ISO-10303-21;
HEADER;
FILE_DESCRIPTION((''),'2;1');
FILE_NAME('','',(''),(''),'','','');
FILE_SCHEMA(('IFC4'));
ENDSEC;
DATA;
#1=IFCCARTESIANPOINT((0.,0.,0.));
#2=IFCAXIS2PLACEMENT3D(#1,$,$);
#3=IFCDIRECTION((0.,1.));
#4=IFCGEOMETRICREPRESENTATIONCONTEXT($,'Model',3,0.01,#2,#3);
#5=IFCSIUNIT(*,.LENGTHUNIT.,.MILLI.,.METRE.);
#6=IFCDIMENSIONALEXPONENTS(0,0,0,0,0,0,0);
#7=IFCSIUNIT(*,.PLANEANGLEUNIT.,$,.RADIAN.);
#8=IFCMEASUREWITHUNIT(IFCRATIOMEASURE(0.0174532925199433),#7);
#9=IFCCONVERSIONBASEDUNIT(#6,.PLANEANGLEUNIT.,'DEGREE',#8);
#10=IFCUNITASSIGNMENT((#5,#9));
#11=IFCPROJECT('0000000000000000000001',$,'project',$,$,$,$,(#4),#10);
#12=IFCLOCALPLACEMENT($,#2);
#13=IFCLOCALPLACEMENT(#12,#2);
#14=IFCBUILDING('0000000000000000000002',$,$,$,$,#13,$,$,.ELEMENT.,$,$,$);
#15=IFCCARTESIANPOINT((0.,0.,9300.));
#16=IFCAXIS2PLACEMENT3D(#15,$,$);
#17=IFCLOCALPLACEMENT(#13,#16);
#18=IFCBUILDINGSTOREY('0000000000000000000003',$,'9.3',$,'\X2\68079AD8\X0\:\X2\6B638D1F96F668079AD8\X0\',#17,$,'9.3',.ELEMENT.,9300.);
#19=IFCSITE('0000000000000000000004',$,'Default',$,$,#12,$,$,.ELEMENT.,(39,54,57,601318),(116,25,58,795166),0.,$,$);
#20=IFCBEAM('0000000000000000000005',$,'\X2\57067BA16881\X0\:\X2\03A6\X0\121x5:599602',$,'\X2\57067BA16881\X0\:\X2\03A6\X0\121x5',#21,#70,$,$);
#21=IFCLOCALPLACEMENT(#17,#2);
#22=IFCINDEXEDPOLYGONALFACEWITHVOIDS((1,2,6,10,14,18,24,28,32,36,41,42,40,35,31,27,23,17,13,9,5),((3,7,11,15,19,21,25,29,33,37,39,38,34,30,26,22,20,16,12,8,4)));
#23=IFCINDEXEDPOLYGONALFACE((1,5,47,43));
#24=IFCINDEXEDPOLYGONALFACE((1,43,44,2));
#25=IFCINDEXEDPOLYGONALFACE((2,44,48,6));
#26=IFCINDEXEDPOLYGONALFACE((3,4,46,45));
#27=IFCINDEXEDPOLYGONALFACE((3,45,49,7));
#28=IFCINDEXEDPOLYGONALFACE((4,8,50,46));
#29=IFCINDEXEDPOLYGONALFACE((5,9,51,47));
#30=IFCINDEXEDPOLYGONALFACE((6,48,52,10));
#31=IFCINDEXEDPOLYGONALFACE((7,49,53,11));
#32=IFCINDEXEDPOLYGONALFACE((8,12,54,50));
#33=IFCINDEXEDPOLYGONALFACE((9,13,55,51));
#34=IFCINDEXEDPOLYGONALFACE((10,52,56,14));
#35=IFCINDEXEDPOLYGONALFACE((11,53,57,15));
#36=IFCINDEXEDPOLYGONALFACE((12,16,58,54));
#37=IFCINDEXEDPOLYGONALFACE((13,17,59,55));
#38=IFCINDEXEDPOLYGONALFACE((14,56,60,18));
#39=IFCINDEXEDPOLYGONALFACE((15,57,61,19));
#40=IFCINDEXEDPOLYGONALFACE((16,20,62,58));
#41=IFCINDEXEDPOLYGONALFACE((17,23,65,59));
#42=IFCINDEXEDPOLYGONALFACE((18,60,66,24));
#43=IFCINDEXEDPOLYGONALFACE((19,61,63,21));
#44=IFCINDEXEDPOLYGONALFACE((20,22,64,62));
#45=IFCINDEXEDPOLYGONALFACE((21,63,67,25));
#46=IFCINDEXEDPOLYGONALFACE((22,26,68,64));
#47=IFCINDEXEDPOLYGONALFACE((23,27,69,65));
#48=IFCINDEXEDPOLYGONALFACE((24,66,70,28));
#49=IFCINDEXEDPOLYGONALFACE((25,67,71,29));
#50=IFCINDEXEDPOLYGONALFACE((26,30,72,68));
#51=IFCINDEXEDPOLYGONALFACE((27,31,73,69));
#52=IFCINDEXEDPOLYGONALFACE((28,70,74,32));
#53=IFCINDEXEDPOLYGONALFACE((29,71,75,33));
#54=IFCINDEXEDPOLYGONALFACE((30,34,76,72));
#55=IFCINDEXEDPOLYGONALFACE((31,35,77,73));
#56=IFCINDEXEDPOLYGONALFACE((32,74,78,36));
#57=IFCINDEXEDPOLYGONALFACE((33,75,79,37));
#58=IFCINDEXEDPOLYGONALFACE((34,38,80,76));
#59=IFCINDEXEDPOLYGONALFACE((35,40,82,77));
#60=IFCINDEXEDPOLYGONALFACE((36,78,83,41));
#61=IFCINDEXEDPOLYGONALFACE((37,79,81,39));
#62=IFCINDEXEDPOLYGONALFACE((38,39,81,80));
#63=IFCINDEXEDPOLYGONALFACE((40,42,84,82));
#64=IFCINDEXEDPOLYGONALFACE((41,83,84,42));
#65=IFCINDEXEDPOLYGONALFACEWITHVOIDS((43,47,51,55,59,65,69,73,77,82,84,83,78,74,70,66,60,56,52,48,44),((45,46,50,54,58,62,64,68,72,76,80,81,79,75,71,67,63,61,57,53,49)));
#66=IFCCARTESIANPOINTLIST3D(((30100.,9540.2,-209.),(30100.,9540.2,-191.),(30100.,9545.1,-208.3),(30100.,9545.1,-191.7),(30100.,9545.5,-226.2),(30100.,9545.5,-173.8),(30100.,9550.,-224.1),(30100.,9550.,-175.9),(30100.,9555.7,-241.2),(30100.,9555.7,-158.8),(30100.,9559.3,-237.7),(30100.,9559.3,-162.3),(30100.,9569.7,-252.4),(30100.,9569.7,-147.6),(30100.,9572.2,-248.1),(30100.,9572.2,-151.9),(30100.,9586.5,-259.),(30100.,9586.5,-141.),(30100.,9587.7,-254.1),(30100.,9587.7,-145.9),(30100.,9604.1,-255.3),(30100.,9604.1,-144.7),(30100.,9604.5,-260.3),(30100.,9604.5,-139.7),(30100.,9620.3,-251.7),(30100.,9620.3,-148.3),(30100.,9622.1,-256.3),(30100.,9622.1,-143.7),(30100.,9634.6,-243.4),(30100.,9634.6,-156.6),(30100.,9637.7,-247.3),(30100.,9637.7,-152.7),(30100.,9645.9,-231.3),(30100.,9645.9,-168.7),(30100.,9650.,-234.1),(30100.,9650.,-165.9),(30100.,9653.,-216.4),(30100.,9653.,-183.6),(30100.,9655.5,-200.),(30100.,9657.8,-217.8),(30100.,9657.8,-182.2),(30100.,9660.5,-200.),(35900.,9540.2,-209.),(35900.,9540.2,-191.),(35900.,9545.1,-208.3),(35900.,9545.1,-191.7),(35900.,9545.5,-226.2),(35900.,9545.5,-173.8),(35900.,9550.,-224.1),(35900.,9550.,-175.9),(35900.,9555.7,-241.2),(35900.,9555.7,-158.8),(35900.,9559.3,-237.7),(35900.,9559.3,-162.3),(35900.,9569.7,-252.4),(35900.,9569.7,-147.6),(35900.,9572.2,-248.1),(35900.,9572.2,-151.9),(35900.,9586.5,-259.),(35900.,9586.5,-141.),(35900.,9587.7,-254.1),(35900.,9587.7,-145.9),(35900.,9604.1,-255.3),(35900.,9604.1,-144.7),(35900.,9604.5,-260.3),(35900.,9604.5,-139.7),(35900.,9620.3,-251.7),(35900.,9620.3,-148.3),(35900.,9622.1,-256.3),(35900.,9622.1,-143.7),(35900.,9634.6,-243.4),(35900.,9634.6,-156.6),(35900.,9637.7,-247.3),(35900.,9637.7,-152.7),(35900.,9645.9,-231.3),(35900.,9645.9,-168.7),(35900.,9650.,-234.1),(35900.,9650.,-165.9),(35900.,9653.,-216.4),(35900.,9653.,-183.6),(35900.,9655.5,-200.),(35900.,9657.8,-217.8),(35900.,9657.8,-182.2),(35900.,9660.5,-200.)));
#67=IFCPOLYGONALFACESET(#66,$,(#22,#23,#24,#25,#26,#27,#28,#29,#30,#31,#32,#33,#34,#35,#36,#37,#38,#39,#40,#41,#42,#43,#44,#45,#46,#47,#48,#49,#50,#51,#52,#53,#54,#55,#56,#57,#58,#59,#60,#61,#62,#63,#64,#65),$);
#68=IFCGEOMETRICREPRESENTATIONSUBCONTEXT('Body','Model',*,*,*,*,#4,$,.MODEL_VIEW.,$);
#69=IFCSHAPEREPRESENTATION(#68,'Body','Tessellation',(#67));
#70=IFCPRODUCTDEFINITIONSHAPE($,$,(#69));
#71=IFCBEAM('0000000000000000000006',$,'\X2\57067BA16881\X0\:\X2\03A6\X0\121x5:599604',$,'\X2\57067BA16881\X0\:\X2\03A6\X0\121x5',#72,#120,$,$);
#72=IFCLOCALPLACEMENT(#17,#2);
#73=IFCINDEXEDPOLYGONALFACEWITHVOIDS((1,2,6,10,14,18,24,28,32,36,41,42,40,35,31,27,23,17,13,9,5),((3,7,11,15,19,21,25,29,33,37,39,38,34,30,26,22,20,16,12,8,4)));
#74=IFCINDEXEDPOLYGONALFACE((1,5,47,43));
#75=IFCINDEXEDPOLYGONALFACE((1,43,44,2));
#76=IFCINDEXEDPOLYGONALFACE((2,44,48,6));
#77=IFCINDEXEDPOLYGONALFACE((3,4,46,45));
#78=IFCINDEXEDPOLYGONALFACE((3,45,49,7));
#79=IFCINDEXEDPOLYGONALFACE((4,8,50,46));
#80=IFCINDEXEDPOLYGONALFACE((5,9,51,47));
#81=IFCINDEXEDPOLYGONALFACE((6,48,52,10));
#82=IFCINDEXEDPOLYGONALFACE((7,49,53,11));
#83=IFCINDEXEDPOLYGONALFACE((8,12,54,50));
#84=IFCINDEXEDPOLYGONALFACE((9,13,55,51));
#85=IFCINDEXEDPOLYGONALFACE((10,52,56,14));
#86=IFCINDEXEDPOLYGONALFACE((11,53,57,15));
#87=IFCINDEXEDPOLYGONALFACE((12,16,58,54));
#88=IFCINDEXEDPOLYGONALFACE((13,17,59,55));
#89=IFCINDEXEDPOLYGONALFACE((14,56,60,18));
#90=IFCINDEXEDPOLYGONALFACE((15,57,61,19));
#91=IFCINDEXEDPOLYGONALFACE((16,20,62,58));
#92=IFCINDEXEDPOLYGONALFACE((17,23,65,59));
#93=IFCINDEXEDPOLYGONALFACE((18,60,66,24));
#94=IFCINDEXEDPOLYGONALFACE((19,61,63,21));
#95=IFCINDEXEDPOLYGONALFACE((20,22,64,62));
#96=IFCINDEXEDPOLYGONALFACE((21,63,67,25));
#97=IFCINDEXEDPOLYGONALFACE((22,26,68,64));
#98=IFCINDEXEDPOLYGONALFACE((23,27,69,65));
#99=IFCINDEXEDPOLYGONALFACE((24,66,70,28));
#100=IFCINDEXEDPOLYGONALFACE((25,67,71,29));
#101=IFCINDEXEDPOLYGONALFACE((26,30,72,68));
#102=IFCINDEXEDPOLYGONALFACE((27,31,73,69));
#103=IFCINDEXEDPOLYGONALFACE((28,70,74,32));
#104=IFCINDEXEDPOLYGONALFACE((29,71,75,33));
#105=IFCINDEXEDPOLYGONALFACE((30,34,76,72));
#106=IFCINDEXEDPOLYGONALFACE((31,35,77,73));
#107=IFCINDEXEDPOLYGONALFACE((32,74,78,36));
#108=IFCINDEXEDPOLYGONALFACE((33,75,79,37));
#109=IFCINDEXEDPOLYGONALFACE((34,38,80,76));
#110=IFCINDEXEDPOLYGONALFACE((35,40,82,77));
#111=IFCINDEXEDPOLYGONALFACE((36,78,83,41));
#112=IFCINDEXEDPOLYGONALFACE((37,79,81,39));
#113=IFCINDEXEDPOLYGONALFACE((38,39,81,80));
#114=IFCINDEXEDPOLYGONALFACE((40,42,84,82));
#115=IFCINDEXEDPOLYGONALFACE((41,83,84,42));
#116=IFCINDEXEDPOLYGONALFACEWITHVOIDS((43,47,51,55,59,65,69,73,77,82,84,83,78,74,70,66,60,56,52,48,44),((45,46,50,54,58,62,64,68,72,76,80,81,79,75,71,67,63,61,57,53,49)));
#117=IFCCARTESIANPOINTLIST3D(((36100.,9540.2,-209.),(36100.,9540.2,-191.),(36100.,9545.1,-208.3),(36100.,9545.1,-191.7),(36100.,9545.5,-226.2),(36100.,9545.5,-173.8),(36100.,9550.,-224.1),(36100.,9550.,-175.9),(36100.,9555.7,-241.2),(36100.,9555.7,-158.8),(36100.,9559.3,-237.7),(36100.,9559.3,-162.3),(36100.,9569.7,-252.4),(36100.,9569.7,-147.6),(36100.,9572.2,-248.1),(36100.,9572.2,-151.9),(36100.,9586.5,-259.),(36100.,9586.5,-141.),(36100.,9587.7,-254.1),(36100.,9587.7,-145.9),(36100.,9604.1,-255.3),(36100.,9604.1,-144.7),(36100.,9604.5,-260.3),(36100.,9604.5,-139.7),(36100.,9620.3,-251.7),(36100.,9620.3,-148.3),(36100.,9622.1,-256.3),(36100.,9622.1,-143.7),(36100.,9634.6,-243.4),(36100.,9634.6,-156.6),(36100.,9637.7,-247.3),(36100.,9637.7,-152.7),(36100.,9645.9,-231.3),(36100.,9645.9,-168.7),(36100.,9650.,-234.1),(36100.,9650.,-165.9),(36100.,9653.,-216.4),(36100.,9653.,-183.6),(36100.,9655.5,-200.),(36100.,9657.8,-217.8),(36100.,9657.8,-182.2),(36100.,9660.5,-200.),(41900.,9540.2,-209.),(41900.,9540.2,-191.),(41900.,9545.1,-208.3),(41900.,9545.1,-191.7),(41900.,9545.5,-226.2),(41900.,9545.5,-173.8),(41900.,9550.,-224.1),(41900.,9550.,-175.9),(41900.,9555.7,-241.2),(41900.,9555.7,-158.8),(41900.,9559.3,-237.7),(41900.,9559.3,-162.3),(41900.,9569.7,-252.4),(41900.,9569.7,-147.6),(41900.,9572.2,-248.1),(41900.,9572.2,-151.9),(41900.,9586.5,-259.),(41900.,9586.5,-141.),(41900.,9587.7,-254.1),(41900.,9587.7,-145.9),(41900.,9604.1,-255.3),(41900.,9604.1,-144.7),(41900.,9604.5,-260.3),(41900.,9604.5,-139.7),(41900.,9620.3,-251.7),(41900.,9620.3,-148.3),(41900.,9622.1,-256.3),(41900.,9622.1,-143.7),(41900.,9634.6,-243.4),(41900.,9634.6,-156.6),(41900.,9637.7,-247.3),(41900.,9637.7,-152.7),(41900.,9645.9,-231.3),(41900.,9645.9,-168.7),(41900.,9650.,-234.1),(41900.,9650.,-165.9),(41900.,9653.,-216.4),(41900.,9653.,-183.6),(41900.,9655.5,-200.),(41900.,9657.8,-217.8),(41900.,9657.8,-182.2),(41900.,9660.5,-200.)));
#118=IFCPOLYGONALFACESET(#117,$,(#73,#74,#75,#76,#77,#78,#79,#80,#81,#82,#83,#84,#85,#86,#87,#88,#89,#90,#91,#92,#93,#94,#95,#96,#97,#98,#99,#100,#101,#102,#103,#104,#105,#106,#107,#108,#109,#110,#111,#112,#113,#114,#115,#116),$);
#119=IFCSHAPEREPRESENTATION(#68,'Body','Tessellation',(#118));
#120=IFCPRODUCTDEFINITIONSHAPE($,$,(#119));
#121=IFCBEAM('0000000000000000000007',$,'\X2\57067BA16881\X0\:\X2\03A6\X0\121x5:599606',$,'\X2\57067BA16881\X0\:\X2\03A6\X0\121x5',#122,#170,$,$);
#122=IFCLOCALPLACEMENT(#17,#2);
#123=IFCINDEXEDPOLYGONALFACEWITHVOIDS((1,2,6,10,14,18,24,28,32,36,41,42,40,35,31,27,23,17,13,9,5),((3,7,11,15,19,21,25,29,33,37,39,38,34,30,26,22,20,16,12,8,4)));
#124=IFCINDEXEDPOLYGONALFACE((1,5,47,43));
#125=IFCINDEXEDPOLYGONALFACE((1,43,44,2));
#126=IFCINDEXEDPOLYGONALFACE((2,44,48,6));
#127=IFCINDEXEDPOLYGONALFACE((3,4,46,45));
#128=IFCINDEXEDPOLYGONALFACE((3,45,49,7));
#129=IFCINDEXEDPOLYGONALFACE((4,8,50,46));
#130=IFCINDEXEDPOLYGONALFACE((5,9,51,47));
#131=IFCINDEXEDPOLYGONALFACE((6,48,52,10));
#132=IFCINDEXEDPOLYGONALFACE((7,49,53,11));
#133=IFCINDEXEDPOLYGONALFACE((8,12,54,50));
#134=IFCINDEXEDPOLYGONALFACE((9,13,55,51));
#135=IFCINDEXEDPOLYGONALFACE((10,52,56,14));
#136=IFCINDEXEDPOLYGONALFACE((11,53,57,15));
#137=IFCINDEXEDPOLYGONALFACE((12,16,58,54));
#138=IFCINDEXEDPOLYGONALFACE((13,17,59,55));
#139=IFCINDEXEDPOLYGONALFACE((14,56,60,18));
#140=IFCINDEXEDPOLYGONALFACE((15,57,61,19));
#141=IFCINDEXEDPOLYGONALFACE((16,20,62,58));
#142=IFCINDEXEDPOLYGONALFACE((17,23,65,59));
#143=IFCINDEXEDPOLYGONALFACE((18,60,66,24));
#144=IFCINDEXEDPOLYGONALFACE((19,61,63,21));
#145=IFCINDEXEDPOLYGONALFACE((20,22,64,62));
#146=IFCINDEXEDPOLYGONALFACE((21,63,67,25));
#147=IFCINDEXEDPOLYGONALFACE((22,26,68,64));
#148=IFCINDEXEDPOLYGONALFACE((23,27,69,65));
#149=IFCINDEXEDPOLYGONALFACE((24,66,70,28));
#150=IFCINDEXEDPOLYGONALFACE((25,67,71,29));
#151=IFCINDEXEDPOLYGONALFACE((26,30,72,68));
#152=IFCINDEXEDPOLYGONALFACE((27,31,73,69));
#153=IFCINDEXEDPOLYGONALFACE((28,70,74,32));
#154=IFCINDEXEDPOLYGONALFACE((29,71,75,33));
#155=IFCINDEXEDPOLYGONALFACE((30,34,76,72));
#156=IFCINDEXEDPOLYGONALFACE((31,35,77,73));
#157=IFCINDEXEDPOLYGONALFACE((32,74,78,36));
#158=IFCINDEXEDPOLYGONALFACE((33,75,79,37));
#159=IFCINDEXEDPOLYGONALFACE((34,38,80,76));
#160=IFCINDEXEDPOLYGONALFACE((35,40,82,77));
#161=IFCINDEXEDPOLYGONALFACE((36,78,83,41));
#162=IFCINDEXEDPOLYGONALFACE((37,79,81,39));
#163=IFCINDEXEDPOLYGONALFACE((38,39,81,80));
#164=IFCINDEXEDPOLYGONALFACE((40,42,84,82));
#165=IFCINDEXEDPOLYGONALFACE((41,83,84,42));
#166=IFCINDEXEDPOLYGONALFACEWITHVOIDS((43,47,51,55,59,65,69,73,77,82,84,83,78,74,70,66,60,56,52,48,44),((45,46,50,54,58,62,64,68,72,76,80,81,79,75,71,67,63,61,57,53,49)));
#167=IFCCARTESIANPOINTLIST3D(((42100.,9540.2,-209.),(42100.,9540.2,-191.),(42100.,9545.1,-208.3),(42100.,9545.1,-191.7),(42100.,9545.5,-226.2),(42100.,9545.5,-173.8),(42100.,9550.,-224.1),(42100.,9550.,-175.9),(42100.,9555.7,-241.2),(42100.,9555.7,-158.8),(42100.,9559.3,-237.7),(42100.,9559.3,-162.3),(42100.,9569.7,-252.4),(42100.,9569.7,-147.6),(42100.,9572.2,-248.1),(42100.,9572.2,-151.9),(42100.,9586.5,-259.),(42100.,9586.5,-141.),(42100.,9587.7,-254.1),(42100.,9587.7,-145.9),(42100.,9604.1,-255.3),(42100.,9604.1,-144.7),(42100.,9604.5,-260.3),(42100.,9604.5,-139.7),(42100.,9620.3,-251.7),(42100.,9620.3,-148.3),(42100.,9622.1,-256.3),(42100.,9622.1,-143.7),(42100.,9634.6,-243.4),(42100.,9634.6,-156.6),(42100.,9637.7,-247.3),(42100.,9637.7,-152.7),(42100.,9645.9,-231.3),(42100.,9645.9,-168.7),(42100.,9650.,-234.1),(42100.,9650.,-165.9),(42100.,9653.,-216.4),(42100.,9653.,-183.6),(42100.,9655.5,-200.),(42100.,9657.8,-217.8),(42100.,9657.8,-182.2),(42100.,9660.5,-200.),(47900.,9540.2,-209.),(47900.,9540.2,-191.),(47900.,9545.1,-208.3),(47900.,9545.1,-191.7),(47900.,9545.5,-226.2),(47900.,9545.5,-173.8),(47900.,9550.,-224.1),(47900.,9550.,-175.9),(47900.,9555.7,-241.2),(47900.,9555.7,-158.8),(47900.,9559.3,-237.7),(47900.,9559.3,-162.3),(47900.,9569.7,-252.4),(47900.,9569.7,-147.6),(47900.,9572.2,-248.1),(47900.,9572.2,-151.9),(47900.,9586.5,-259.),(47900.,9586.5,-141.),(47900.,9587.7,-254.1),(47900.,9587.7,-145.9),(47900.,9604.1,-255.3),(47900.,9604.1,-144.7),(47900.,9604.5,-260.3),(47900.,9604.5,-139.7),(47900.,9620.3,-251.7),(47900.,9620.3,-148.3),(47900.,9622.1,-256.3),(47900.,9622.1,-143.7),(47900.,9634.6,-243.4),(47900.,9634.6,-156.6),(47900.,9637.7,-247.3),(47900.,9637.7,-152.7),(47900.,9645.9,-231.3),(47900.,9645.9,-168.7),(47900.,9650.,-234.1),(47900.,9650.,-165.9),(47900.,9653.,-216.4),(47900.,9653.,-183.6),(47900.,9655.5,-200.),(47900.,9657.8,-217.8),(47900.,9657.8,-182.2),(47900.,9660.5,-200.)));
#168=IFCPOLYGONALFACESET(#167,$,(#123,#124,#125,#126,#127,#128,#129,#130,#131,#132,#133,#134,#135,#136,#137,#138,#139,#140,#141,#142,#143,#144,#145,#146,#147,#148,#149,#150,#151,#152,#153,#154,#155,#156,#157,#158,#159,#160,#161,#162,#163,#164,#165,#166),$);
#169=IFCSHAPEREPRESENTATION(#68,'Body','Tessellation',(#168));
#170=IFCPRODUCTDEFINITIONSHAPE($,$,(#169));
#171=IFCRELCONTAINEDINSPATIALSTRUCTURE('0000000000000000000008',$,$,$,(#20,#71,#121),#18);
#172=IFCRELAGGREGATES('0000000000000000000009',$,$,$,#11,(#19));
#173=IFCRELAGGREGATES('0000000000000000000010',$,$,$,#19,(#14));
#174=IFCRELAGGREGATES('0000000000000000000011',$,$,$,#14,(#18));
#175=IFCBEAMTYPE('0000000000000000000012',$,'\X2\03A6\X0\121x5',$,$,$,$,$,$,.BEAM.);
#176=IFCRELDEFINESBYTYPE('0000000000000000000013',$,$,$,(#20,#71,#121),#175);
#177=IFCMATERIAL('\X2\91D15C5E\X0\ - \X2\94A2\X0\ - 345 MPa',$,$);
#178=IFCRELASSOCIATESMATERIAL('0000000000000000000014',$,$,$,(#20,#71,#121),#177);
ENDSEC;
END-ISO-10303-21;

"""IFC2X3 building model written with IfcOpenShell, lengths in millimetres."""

from ifc_helpers import new_model, entity, si_unit, converted_unit, direction, frame, origin, origin_2d_with_axis, place, context, subcontext, project, spatial, hollow_circle, extrude, material, type_object, element, save


model = new_model("IFC2X3")

# Units and contexts
model_context = context("Model", 3, precision=0.01, world=origin(), true_north=direction((0.0, 1.0)))
body_context = subcontext(model_context, "Body", "Model", "MODEL_VIEW")
ifc_project = project(units=[si_unit("LENGTHUNIT", "METRE", prefix="MILLI"), converted_unit("PLANEANGLEUNIT", "DEGREE", entity("IfcRatioMeasure", 0.0174532925199433), si_unit("PLANEANGLEUNIT", "RADIAN"), dimensions=[0, 0, 0, 0, 0, 0, 0])], contexts=[model_context])

# Site, building, storey
site_placement = place(None, origin())
site = spatial("IfcSite", under=ifc_project, at=site_placement, Name="Default", CompositionType="ELEMENT", RefLatitude=(39, 54, 57, 601318), RefLongitude=(116, 25, 58, 795166), RefElevation=0.0)
building_placement = place(site_placement, origin())
building = spatial("IfcBuilding", under=site, at=building_placement, CompositionType="ELEMENT")
storey_placement = place(building_placement, frame((0.0, 0.0, 9300.0)))
storey = spatial("IfcBuildingStorey", under=building, at=storey_placement, Name="9.3", ObjectType="标高:正负零标高", LongName="9.3", CompositionType="ELEMENT", Elevation=9300.0)

# Beams
ifc_material = material(Name="金属 - 钢 - 345 MPa")
beam_type_1 = type_object("IfcBeamType", Name="Φ121x5", PredefinedType="BEAM")
for number, where, name in (
    (1, (30000.0, 9600.0, 0.0), "圆管梁:Φ121x5:599602"),
    (2, (36000.0, 9600.0, 0.0), "圆管梁:Φ121x5:599604"),
    (3, (42000.0, 9600.0, 0.0), "圆管梁:Φ121x5:599606"),
):
    element("IfcBeam", number, at=place(storey_placement, frame(where)), inside=storey, type_object=beam_type_1, material=ifc_material, Name=name, ObjectType="圆管梁:Φ121x5", context=body_context, shape_type="SweptSolid", body=[
        extrude(hollow_circle(Radius=60.5, WallThickness=5.0, at=origin_2d_with_axis()), frame((100.0, 0.0, -200.0), z_axis=(1.0, 0.0, 0.0), x_axis=(0.0, 1.0, 0.0)), (0.0, 0.0, 1.0), 5800.0),
    ])

save(model, "model.ifc")
